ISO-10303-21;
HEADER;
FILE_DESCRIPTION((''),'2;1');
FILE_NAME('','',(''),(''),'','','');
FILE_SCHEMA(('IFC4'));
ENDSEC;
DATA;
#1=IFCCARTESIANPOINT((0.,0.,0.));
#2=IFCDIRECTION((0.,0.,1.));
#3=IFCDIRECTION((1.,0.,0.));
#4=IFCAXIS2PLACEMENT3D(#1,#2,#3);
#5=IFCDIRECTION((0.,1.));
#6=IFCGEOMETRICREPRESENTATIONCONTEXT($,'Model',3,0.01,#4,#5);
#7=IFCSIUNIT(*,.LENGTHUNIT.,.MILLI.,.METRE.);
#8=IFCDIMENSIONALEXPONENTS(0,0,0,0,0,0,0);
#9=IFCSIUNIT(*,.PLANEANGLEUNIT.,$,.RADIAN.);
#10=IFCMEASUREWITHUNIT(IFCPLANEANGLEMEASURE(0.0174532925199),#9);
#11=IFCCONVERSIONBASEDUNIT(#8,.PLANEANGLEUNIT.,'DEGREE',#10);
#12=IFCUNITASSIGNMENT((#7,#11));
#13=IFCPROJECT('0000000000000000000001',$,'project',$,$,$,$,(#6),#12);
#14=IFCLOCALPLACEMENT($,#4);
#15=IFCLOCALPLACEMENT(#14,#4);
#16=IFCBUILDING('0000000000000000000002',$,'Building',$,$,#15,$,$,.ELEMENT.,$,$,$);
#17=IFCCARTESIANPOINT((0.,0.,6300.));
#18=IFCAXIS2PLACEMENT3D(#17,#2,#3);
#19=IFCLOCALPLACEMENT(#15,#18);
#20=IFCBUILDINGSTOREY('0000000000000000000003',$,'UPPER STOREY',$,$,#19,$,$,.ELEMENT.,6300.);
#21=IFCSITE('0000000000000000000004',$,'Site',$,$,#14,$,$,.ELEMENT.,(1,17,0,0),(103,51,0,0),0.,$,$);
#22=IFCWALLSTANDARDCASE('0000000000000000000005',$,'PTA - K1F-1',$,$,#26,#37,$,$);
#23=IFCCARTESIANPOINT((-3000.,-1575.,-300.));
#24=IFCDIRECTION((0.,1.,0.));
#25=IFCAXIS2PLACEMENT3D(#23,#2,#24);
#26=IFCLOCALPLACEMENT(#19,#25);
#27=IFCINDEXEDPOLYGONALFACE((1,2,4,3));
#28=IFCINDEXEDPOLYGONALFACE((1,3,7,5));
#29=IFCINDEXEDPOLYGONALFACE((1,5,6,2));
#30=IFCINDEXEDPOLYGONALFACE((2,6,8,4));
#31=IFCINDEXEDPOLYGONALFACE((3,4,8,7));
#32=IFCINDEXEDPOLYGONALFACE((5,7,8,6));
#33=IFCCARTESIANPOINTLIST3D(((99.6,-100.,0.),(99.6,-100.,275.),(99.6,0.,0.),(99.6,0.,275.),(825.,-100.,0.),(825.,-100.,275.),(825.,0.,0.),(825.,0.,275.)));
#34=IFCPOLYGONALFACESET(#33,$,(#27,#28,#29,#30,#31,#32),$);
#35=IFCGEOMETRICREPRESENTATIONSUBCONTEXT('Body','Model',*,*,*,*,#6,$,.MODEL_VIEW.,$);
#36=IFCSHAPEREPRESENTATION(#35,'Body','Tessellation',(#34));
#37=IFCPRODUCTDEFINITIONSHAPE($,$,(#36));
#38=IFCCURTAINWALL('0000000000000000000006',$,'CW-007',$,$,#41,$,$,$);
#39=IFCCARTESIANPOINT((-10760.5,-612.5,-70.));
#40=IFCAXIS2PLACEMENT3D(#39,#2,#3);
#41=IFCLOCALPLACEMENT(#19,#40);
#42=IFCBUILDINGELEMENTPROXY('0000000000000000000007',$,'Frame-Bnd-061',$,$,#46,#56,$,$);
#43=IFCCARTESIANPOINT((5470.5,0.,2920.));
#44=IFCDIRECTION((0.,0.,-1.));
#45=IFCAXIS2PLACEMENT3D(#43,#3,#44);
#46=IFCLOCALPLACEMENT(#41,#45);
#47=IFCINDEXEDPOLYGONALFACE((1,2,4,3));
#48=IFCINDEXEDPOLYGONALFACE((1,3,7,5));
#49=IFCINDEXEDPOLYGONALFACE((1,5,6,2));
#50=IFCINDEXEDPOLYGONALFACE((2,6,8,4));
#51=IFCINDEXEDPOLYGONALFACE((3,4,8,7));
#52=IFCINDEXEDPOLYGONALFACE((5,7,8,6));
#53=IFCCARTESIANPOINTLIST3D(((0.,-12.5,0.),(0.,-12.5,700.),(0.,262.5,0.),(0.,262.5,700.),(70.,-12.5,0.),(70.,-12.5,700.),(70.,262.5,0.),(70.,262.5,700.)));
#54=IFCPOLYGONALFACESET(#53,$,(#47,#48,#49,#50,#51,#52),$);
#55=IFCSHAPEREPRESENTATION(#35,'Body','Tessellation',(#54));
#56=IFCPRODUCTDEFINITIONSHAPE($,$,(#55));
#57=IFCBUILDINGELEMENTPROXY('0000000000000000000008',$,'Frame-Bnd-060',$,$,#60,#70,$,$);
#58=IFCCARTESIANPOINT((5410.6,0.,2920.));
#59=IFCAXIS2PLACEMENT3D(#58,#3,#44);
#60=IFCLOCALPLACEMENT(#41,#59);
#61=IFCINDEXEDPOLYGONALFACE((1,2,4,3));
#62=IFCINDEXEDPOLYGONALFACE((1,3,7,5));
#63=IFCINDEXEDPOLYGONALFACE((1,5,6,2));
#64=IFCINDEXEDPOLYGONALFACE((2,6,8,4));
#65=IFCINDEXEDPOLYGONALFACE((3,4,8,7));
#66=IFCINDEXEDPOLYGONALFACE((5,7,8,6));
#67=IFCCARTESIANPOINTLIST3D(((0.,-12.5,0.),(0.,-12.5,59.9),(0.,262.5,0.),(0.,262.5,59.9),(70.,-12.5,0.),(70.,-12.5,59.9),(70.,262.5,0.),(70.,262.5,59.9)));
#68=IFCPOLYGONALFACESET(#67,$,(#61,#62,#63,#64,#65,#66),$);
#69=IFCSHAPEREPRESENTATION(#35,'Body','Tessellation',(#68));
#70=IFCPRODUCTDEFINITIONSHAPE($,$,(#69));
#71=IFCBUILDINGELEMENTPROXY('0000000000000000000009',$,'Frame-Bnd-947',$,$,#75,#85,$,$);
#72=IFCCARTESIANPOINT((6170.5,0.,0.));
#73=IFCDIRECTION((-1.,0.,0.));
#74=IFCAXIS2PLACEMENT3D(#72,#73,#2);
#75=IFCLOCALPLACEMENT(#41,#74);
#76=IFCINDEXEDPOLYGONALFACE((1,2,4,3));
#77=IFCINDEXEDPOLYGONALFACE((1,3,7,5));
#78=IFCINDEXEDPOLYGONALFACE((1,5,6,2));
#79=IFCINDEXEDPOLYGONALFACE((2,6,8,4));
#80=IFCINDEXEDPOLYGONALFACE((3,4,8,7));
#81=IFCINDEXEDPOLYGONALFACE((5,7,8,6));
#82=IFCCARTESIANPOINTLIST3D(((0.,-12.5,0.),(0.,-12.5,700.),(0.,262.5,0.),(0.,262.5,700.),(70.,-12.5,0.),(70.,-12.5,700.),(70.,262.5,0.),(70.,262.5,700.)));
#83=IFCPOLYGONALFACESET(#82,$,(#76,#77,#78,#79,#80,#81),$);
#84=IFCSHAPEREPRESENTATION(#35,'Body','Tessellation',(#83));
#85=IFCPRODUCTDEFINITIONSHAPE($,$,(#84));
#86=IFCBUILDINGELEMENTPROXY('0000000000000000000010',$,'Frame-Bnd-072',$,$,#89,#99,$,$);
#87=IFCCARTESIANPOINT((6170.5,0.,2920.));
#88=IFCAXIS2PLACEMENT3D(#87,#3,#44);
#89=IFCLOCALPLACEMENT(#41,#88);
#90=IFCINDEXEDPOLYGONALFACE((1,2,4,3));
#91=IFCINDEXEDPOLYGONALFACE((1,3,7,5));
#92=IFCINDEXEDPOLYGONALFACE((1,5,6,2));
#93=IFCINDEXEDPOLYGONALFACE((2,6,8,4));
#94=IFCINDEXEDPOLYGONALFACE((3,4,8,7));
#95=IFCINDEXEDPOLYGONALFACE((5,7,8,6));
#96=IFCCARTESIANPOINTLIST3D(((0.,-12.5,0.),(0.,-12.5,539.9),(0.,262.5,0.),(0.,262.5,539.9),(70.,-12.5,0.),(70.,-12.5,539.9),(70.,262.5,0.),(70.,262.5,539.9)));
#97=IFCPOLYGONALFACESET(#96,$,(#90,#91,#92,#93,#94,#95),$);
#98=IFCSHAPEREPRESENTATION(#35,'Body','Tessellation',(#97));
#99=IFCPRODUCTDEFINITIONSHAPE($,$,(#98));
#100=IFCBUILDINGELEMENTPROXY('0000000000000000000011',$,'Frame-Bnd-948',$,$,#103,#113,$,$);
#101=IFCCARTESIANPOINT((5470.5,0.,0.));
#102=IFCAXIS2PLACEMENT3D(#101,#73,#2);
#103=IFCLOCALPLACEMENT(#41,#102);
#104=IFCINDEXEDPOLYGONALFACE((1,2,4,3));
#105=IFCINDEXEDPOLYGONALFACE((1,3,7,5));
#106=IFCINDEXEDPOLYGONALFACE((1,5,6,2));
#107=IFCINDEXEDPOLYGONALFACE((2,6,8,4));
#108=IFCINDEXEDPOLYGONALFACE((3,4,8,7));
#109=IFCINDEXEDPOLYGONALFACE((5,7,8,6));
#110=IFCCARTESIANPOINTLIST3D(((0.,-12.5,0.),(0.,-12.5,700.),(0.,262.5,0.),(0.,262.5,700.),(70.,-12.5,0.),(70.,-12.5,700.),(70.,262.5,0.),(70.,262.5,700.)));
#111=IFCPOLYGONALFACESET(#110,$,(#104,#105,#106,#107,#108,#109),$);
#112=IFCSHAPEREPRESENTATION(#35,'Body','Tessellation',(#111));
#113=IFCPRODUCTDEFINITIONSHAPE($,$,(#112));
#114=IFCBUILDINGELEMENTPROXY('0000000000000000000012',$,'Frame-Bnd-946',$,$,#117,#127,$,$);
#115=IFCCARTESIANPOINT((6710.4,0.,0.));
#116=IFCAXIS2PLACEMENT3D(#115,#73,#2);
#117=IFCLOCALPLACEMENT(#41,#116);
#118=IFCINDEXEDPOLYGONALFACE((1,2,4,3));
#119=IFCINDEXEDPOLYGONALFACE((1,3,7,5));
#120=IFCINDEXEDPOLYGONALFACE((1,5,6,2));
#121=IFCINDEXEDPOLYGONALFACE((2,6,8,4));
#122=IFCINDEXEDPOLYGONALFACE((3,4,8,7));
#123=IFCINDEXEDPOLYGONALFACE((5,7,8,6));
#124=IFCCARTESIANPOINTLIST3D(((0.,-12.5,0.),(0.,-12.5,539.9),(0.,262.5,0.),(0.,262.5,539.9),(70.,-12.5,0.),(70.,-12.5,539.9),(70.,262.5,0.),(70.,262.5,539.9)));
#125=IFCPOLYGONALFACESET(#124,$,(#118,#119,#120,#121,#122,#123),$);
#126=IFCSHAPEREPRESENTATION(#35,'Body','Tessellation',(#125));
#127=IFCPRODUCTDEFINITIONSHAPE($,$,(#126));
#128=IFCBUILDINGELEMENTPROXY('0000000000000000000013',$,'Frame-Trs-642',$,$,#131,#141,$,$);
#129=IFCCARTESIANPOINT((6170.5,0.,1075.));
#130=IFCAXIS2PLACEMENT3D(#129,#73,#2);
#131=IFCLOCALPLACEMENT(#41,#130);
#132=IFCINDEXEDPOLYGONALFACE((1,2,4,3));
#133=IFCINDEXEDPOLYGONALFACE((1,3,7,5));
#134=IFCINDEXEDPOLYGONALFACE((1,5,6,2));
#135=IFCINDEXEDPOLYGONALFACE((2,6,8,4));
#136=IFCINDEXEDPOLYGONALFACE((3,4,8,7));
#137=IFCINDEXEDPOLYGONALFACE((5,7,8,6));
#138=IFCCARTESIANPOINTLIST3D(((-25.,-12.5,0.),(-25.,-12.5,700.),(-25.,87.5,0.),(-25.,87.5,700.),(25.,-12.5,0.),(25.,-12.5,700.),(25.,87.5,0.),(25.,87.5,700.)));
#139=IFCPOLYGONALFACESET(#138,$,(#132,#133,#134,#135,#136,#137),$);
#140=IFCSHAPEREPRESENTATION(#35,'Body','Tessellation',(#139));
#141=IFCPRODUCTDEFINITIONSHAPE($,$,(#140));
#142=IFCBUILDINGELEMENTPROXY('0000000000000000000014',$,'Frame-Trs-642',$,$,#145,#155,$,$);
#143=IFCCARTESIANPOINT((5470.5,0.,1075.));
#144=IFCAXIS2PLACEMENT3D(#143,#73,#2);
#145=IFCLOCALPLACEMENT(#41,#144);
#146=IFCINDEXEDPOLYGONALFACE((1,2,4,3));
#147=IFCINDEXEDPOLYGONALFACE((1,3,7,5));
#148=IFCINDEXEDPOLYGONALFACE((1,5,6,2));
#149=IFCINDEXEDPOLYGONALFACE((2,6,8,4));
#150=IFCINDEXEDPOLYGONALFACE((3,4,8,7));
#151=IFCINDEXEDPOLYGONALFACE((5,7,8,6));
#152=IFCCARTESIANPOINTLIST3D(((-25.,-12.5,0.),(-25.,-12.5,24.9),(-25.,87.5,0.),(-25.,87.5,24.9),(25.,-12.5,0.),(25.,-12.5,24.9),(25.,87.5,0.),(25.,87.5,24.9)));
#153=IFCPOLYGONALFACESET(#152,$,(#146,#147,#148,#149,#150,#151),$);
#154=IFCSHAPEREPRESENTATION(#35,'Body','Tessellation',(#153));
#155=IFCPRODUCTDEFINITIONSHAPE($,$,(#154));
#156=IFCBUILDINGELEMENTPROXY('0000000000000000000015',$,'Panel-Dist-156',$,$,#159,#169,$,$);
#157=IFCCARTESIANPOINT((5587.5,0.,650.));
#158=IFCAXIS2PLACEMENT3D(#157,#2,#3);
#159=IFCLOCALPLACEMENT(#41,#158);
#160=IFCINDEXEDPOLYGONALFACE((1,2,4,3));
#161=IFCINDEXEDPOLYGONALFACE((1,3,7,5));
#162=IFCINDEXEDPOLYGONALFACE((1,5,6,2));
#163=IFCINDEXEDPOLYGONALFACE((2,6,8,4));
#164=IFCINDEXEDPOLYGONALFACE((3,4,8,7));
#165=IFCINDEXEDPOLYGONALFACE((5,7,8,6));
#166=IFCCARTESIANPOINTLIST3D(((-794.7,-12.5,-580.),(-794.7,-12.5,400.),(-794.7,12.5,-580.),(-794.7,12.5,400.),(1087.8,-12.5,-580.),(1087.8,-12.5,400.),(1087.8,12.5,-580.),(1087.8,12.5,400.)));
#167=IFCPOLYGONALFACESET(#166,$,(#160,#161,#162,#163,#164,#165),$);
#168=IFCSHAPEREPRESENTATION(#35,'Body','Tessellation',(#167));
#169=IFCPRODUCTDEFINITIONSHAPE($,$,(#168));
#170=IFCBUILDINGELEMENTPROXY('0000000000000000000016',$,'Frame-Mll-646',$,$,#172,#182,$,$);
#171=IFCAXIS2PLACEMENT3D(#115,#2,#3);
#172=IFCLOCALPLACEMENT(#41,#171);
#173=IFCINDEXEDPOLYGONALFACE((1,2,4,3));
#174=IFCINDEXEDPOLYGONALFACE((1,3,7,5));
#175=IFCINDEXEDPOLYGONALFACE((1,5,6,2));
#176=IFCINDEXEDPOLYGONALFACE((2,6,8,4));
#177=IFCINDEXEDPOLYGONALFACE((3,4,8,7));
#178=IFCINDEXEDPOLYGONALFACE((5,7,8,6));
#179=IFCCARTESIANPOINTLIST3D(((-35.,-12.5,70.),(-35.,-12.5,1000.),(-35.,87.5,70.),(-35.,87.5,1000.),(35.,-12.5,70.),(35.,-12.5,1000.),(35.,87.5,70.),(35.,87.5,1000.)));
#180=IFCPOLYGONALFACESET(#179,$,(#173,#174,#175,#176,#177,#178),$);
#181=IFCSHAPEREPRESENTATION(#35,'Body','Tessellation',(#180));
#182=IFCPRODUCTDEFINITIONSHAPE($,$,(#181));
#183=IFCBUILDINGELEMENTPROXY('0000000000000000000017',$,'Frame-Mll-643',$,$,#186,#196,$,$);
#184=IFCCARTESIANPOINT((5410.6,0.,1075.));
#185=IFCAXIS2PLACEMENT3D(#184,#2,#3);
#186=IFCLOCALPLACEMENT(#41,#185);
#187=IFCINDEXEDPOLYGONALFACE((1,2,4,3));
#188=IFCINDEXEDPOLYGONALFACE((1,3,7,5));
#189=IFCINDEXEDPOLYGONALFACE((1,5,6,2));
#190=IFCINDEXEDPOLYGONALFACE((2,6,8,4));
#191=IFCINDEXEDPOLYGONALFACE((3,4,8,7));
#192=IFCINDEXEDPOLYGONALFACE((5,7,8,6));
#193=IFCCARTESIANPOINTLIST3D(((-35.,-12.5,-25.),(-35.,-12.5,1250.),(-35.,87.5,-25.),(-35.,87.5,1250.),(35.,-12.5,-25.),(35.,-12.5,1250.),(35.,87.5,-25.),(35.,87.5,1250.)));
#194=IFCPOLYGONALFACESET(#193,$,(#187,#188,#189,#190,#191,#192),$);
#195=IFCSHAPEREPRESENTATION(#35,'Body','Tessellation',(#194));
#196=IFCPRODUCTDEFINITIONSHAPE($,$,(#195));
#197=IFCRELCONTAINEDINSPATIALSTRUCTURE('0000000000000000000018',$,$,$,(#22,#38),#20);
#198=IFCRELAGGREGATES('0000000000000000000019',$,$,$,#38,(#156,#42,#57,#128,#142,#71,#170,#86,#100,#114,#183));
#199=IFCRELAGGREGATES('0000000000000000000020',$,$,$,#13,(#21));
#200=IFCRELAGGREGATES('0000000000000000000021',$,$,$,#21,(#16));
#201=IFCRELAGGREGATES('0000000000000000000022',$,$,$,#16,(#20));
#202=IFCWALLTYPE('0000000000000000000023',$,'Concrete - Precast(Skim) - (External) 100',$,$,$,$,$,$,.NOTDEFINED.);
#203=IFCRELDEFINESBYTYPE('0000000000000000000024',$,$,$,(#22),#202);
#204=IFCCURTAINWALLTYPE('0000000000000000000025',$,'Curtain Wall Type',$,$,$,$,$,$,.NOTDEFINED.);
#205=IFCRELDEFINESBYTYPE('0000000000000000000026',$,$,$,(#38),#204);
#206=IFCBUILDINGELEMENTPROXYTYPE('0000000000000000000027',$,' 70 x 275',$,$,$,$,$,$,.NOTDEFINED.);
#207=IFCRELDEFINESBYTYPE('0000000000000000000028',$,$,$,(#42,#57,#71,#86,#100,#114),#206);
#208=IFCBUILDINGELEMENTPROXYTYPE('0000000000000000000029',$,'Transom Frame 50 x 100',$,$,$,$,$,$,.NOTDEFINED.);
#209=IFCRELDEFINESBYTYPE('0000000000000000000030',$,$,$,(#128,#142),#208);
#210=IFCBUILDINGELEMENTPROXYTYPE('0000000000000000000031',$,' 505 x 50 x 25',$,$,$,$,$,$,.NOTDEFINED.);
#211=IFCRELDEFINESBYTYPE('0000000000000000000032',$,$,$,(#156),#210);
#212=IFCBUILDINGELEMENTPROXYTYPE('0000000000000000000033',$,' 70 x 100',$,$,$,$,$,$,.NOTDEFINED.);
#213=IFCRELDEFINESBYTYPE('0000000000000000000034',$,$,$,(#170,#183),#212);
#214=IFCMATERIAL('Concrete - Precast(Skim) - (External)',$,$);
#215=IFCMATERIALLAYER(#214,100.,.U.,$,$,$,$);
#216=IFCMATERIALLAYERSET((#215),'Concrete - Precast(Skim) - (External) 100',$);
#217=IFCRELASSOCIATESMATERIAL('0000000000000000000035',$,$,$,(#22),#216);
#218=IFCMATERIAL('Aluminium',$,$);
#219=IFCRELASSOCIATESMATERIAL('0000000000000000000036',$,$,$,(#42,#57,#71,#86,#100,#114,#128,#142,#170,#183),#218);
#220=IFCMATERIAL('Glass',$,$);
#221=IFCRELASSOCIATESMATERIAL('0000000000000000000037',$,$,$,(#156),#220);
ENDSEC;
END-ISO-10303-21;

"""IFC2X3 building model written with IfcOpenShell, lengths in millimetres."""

from ifc_helpers import new_model, entity, si_unit, converted_unit, direction, frame, origin_with_axes, place, context, subcontext, project, spatial, polyline, outline, extrude, material, layer, layer_set, layer_usage, type_object, element, aggregate, save


model = new_model("IFC2X3")

# Units and contexts
model_context = context("Model", 3, precision=0.01, world=origin_with_axes(), true_north=direction((0.0, 1.0)))
body_context = subcontext(model_context, "Body", "Model", "MODEL_VIEW")
ifc_project = project(units=[si_unit("LENGTHUNIT", "METRE", prefix="MILLI"), converted_unit("PLANEANGLEUNIT", "DEGREE", entity("IfcPlaneAngleMeasure", 0.0174532925199), si_unit("PLANEANGLEUNIT", "RADIAN"), dimensions=[0, 0, 0, 0, 0, 0, 0])], contexts=[model_context])

# Site, building, storey
site_placement = place(None, origin_with_axes())
site = spatial("IfcSite", under=ifc_project, at=site_placement, Name="Site", CompositionType="ELEMENT", RefLatitude=(1, 17, 0, 0), RefLongitude=(103, 51, 0, 0), RefElevation=0.0)
building_placement = place(site_placement, origin_with_axes())
building = spatial("IfcBuilding", under=site, at=building_placement, Name="Building", CompositionType="ELEMENT")
storey_placement = place(building_placement, frame((0.0, 0.0, 6300.0), z_axis=(0.0, 0.0, 1.0), x_axis=(1.0, 0.0, 0.0)))
storey = spatial("IfcBuildingStorey", under=building, at=storey_placement, Name="UPPER STOREY", CompositionType="ELEMENT", Elevation=6300.0)

# Wall
ifc_material_1 = material(Name="Concrete - Precast(Skim) - (External)")
ifc_layer_1 = layer(ifc_material_1, 100.0, ventilated="UNKNOWN")
ifc_layer_set_1 = layer_set([ifc_layer_1], Name="Concrete - Precast(Skim) - (External) 100")
wall_type_1 = type_object("IfcWallType", Name="Concrete - Precast(Skim) - (External) 100", PredefinedType="NOTDEFINED")
ifc_layer_usage_1 = layer_usage(ifc_layer_set_1, "AXIS2", "NEGATIVE", 0.0)
wall_1_placement = place(storey_placement, frame((-3000.0, -1575.0, -300.0), z_axis=(0.0, 0.0, 1.0), x_axis=(0.0, 1.0, 0.0)))
element("IfcWallStandardCase", 1, at=wall_1_placement, inside=storey, type_object=wall_type_1, material=ifc_layer_usage_1, Name="PTA - K1F-1", context=body_context, shape_type="SweptSolid", body=[
    extrude(outline(polyline([(99.6, -100.0), (825.0, -100.0), (825.0, 0.0), (99.6, 0.0), (99.6, -100.0)])), origin_with_axes(), (0.0, 0.0, 1.0), 275.0),
])

# Curtain wall, building element proxies
curtain_wall_type = type_object("IfcCurtainWallType", Name="Curtain Wall Type", PredefinedType="NOTDEFINED")
curtain_wall_placement = place(storey_placement, frame((-10760.5, -612.5, -70.0), z_axis=(0.0, 0.0, 1.0), x_axis=(1.0, 0.0, 0.0)))
curtain_wall = element("IfcCurtainWall", 2, at=curtain_wall_placement, inside=storey, type_object=curtain_wall_type, Name="CW-007")
ifc_material_2 = material(Name="Aluminium")
building_element_proxy_type_1 = type_object("IfcBuildingElementProxyType", Name=" 70 x 275", PredefinedType="NOTDEFINED")
proxy_1_placement = place(curtain_wall_placement, frame((5470.5, 0.0, 2920.0), z_axis=(1.0, 0.0, 0.0), x_axis=(0.0, 0.0, -1.0)))
proxy_1 = element("IfcBuildingElementProxy", 3, at=proxy_1_placement, type_object=building_element_proxy_type_1, material=ifc_material_2, Name="Frame-Bnd-061", context=body_context, shape_type="SweptSolid", body=[
    extrude(outline(polyline([(-262.5, 70.0), (-262.5, 0.0), (12.5, 0.0), (12.5, 70.0), (-262.5, 70.0)])), frame((0.0, 0.0, 0.0), z_axis=(0.0, 0.0, 1.0), x_axis=(0.0, -1.0, 0.0)), (0.0, 0.0, 1.0), 700.0),
])
proxy_2_placement = place(curtain_wall_placement, frame((5410.6, 0.0, 2920.0), z_axis=(1.0, 0.0, 0.0), x_axis=(0.0, 0.0, -1.0)))
proxy_2 = element("IfcBuildingElementProxy", 4, at=proxy_2_placement, type_object=building_element_proxy_type_1, material=ifc_material_2, Name="Frame-Bnd-060", context=body_context, shape_type="SweptSolid", body=[
    extrude(outline(polyline([(-262.5, 70.0), (-262.5, 0.0), (12.5, 0.0), (12.5, 70.0), (-262.5, 70.0)])), frame((0.0, 0.0, 0.0), z_axis=(0.0, 0.0, 1.0), x_axis=(0.0, -1.0, 0.0)), (0.0, 0.0, 1.0), 59.9),
])
proxy_3_placement = place(curtain_wall_placement, frame((6170.5, 0.0, 0.0), z_axis=(-1.0, 0.0, 0.0), x_axis=(0.0, 0.0, 1.0)))
proxy_3 = element("IfcBuildingElementProxy", 5, at=proxy_3_placement, type_object=building_element_proxy_type_1, material=ifc_material_2, Name="Frame-Bnd-947", context=body_context, shape_type="SweptSolid", body=[
    extrude(outline(polyline([(262.5, -70.0), (262.5, 0.0), (-12.5, 0.0), (-12.5, -70.0), (262.5, -70.0)])), frame((0.0, 0.0, 0.0), z_axis=(0.0, 0.0, 1.0), x_axis=(0.0, 1.0, 0.0)), (0.0, 0.0, 1.0), 700.0),
])
proxy_4_placement = place(curtain_wall_placement, frame((6170.5, 0.0, 2920.0), z_axis=(1.0, 0.0, 0.0), x_axis=(0.0, 0.0, -1.0)))
proxy_4 = element("IfcBuildingElementProxy", 6, at=proxy_4_placement, type_object=building_element_proxy_type_1, material=ifc_material_2, Name="Frame-Bnd-072", context=body_context, shape_type="SweptSolid", body=[
    extrude(outline(polyline([(-262.5, 70.0), (-262.5, 0.0), (12.5, 0.0), (12.5, 70.0), (-262.5, 70.0)])), frame((0.0, 0.0, 0.0), z_axis=(0.0, 0.0, 1.0), x_axis=(0.0, -1.0, 0.0)), (0.0, 0.0, 1.0), 539.9),
])
proxy_5_placement = place(curtain_wall_placement, frame((5470.5, 0.0, 0.0), z_axis=(-1.0, 0.0, 0.0), x_axis=(0.0, 0.0, 1.0)))
proxy_5 = element("IfcBuildingElementProxy", 7, at=proxy_5_placement, type_object=building_element_proxy_type_1, material=ifc_material_2, Name="Frame-Bnd-948", context=body_context, shape_type="SweptSolid", body=[
    extrude(outline(polyline([(262.5, -70.0), (262.5, 0.0), (-12.5, 0.0), (-12.5, -70.0), (262.5, -70.0)])), frame((0.0, 0.0, 0.0), z_axis=(0.0, 0.0, 1.0), x_axis=(0.0, 1.0, 0.0)), (0.0, 0.0, 1.0), 700.0),
])
proxy_6_placement = place(curtain_wall_placement, frame((6710.4, 0.0, 0.0), z_axis=(-1.0, 0.0, 0.0), x_axis=(0.0, 0.0, 1.0)))
proxy_6 = element("IfcBuildingElementProxy", 8, at=proxy_6_placement, type_object=building_element_proxy_type_1, material=ifc_material_2, Name="Frame-Bnd-946", context=body_context, shape_type="SweptSolid", body=[
    extrude(outline(polyline([(262.5, -70.0), (262.5, 0.0), (-12.5, 0.0), (-12.5, -70.0), (262.5, -70.0)])), frame((0.0, 0.0, 0.0), z_axis=(0.0, 0.0, 1.0), x_axis=(0.0, 1.0, 0.0)), (0.0, 0.0, 1.0), 539.9),
])
building_element_proxy_type_2 = type_object("IfcBuildingElementProxyType", Name="Transom Frame 50 x 100", PredefinedType="NOTDEFINED")
proxy_7_placement = place(curtain_wall_placement, frame((6170.5, 0.0, 1075.0), z_axis=(-1.0, 0.0, 0.0), x_axis=(0.0, 0.0, 1.0)))
proxy_7 = element("IfcBuildingElementProxy", 9, at=proxy_7_placement, type_object=building_element_proxy_type_2, material=ifc_material_2, Name="Frame-Trs-642", context=body_context, shape_type="SweptSolid", body=[
    extrude(outline(polyline([(87.5, -25.0), (87.5, 25.0), (-12.5, 25.0), (-12.5, -25.0), (87.5, -25.0)])), frame((0.0, 0.0, 0.0), z_axis=(0.0, 0.0, 1.0), x_axis=(0.0, 1.0, 0.0)), (0.0, 0.0, 1.0), 700.0),
])
proxy_8_placement = place(curtain_wall_placement, frame((5470.5, 0.0, 1075.0), z_axis=(-1.0, 0.0, 0.0), x_axis=(0.0, 0.0, 1.0)))
proxy_8 = element("IfcBuildingElementProxy", 10, at=proxy_8_placement, type_object=building_element_proxy_type_2, material=ifc_material_2, Name="Frame-Trs-642", context=body_context, shape_type="SweptSolid", body=[
    extrude(outline(polyline([(87.5, -25.0), (87.5, 25.0), (-12.5, 25.0), (-12.5, -25.0), (87.5, -25.0)])), frame((0.0, 0.0, 0.0), z_axis=(0.0, 0.0, 1.0), x_axis=(0.0, 1.0, 0.0)), (0.0, 0.0, 1.0), 24.9),
])
ifc_material_3 = material(Name="Glass")
building_element_proxy_type_3 = type_object("IfcBuildingElementProxyType", Name=" 505 x 50 x 25", PredefinedType="NOTDEFINED")
proxy_9_placement = place(curtain_wall_placement, frame((5587.5, 0.0, 650.0), z_axis=(0.0, 0.0, 1.0), x_axis=(1.0, 0.0, 0.0)))
proxy_9 = element("IfcBuildingElementProxy", 11, at=proxy_9_placement, type_object=building_element_proxy_type_3, material=ifc_material_3, Name="Panel-Dist-156", context=body_context, shape_type="SweptSolid", body=[
    extrude(outline(polyline([(-794.7, -400.0), (1087.8, -400.0), (1087.8, 580.0), (-794.7, 580.0), (-794.7, -400.0)])), frame((0.0, -12.5, 0.0), z_axis=(0.0, 1.0, 0.0), x_axis=(1.0, 0.0, 0.0)), (0.0, 0.0, 1.0), 25.0),
])
building_element_proxy_type_4 = type_object("IfcBuildingElementProxyType", Name=" 70 x 100", PredefinedType="NOTDEFINED")
proxy_10_placement = place(curtain_wall_placement, frame((6710.4, 0.0, 0.0), z_axis=(0.0, 0.0, 1.0), x_axis=(1.0, 0.0, 0.0)))
proxy_10 = element("IfcBuildingElementProxy", 12, at=proxy_10_placement, type_object=building_element_proxy_type_4, material=ifc_material_2, Name="Frame-Mll-646", context=body_context, shape_type="SweptSolid", body=[
    extrude(outline(polyline([(35.0, 87.5), (-35.0, 87.5), (-35.0, -12.5), (35.0, -12.5), (35.0, 87.5)])), frame((0.0, 0.0, 70.0), z_axis=(0.0, 0.0, 1.0), x_axis=(1.0, 0.0, 0.0)), (0.0, 0.0, 1.0), 930.0),
])
proxy_11_placement = place(curtain_wall_placement, frame((5410.6, 0.0, 1075.0), z_axis=(0.0, 0.0, 1.0), x_axis=(1.0, 0.0, 0.0)))
proxy_11 = element("IfcBuildingElementProxy", 13, at=proxy_11_placement, type_object=building_element_proxy_type_4, material=ifc_material_2, Name="Frame-Mll-643", context=body_context, shape_type="SweptSolid", body=[
    extrude(outline(polyline([(35.0, 87.5), (-35.0, 87.5), (-35.0, -12.5), (35.0, -12.5), (35.0, 87.5)])), frame((0.0, 0.0, -25.0), z_axis=(0.0, 0.0, 1.0), x_axis=(1.0, 0.0, 0.0)), (0.0, 0.0, 1.0), 1275.0),
])
aggregate(curtain_wall, [proxy_9, proxy_1, proxy_2, proxy_7, proxy_8, proxy_3, proxy_10, proxy_4, proxy_5, proxy_6, proxy_11])

save(model, "model.ifc")
